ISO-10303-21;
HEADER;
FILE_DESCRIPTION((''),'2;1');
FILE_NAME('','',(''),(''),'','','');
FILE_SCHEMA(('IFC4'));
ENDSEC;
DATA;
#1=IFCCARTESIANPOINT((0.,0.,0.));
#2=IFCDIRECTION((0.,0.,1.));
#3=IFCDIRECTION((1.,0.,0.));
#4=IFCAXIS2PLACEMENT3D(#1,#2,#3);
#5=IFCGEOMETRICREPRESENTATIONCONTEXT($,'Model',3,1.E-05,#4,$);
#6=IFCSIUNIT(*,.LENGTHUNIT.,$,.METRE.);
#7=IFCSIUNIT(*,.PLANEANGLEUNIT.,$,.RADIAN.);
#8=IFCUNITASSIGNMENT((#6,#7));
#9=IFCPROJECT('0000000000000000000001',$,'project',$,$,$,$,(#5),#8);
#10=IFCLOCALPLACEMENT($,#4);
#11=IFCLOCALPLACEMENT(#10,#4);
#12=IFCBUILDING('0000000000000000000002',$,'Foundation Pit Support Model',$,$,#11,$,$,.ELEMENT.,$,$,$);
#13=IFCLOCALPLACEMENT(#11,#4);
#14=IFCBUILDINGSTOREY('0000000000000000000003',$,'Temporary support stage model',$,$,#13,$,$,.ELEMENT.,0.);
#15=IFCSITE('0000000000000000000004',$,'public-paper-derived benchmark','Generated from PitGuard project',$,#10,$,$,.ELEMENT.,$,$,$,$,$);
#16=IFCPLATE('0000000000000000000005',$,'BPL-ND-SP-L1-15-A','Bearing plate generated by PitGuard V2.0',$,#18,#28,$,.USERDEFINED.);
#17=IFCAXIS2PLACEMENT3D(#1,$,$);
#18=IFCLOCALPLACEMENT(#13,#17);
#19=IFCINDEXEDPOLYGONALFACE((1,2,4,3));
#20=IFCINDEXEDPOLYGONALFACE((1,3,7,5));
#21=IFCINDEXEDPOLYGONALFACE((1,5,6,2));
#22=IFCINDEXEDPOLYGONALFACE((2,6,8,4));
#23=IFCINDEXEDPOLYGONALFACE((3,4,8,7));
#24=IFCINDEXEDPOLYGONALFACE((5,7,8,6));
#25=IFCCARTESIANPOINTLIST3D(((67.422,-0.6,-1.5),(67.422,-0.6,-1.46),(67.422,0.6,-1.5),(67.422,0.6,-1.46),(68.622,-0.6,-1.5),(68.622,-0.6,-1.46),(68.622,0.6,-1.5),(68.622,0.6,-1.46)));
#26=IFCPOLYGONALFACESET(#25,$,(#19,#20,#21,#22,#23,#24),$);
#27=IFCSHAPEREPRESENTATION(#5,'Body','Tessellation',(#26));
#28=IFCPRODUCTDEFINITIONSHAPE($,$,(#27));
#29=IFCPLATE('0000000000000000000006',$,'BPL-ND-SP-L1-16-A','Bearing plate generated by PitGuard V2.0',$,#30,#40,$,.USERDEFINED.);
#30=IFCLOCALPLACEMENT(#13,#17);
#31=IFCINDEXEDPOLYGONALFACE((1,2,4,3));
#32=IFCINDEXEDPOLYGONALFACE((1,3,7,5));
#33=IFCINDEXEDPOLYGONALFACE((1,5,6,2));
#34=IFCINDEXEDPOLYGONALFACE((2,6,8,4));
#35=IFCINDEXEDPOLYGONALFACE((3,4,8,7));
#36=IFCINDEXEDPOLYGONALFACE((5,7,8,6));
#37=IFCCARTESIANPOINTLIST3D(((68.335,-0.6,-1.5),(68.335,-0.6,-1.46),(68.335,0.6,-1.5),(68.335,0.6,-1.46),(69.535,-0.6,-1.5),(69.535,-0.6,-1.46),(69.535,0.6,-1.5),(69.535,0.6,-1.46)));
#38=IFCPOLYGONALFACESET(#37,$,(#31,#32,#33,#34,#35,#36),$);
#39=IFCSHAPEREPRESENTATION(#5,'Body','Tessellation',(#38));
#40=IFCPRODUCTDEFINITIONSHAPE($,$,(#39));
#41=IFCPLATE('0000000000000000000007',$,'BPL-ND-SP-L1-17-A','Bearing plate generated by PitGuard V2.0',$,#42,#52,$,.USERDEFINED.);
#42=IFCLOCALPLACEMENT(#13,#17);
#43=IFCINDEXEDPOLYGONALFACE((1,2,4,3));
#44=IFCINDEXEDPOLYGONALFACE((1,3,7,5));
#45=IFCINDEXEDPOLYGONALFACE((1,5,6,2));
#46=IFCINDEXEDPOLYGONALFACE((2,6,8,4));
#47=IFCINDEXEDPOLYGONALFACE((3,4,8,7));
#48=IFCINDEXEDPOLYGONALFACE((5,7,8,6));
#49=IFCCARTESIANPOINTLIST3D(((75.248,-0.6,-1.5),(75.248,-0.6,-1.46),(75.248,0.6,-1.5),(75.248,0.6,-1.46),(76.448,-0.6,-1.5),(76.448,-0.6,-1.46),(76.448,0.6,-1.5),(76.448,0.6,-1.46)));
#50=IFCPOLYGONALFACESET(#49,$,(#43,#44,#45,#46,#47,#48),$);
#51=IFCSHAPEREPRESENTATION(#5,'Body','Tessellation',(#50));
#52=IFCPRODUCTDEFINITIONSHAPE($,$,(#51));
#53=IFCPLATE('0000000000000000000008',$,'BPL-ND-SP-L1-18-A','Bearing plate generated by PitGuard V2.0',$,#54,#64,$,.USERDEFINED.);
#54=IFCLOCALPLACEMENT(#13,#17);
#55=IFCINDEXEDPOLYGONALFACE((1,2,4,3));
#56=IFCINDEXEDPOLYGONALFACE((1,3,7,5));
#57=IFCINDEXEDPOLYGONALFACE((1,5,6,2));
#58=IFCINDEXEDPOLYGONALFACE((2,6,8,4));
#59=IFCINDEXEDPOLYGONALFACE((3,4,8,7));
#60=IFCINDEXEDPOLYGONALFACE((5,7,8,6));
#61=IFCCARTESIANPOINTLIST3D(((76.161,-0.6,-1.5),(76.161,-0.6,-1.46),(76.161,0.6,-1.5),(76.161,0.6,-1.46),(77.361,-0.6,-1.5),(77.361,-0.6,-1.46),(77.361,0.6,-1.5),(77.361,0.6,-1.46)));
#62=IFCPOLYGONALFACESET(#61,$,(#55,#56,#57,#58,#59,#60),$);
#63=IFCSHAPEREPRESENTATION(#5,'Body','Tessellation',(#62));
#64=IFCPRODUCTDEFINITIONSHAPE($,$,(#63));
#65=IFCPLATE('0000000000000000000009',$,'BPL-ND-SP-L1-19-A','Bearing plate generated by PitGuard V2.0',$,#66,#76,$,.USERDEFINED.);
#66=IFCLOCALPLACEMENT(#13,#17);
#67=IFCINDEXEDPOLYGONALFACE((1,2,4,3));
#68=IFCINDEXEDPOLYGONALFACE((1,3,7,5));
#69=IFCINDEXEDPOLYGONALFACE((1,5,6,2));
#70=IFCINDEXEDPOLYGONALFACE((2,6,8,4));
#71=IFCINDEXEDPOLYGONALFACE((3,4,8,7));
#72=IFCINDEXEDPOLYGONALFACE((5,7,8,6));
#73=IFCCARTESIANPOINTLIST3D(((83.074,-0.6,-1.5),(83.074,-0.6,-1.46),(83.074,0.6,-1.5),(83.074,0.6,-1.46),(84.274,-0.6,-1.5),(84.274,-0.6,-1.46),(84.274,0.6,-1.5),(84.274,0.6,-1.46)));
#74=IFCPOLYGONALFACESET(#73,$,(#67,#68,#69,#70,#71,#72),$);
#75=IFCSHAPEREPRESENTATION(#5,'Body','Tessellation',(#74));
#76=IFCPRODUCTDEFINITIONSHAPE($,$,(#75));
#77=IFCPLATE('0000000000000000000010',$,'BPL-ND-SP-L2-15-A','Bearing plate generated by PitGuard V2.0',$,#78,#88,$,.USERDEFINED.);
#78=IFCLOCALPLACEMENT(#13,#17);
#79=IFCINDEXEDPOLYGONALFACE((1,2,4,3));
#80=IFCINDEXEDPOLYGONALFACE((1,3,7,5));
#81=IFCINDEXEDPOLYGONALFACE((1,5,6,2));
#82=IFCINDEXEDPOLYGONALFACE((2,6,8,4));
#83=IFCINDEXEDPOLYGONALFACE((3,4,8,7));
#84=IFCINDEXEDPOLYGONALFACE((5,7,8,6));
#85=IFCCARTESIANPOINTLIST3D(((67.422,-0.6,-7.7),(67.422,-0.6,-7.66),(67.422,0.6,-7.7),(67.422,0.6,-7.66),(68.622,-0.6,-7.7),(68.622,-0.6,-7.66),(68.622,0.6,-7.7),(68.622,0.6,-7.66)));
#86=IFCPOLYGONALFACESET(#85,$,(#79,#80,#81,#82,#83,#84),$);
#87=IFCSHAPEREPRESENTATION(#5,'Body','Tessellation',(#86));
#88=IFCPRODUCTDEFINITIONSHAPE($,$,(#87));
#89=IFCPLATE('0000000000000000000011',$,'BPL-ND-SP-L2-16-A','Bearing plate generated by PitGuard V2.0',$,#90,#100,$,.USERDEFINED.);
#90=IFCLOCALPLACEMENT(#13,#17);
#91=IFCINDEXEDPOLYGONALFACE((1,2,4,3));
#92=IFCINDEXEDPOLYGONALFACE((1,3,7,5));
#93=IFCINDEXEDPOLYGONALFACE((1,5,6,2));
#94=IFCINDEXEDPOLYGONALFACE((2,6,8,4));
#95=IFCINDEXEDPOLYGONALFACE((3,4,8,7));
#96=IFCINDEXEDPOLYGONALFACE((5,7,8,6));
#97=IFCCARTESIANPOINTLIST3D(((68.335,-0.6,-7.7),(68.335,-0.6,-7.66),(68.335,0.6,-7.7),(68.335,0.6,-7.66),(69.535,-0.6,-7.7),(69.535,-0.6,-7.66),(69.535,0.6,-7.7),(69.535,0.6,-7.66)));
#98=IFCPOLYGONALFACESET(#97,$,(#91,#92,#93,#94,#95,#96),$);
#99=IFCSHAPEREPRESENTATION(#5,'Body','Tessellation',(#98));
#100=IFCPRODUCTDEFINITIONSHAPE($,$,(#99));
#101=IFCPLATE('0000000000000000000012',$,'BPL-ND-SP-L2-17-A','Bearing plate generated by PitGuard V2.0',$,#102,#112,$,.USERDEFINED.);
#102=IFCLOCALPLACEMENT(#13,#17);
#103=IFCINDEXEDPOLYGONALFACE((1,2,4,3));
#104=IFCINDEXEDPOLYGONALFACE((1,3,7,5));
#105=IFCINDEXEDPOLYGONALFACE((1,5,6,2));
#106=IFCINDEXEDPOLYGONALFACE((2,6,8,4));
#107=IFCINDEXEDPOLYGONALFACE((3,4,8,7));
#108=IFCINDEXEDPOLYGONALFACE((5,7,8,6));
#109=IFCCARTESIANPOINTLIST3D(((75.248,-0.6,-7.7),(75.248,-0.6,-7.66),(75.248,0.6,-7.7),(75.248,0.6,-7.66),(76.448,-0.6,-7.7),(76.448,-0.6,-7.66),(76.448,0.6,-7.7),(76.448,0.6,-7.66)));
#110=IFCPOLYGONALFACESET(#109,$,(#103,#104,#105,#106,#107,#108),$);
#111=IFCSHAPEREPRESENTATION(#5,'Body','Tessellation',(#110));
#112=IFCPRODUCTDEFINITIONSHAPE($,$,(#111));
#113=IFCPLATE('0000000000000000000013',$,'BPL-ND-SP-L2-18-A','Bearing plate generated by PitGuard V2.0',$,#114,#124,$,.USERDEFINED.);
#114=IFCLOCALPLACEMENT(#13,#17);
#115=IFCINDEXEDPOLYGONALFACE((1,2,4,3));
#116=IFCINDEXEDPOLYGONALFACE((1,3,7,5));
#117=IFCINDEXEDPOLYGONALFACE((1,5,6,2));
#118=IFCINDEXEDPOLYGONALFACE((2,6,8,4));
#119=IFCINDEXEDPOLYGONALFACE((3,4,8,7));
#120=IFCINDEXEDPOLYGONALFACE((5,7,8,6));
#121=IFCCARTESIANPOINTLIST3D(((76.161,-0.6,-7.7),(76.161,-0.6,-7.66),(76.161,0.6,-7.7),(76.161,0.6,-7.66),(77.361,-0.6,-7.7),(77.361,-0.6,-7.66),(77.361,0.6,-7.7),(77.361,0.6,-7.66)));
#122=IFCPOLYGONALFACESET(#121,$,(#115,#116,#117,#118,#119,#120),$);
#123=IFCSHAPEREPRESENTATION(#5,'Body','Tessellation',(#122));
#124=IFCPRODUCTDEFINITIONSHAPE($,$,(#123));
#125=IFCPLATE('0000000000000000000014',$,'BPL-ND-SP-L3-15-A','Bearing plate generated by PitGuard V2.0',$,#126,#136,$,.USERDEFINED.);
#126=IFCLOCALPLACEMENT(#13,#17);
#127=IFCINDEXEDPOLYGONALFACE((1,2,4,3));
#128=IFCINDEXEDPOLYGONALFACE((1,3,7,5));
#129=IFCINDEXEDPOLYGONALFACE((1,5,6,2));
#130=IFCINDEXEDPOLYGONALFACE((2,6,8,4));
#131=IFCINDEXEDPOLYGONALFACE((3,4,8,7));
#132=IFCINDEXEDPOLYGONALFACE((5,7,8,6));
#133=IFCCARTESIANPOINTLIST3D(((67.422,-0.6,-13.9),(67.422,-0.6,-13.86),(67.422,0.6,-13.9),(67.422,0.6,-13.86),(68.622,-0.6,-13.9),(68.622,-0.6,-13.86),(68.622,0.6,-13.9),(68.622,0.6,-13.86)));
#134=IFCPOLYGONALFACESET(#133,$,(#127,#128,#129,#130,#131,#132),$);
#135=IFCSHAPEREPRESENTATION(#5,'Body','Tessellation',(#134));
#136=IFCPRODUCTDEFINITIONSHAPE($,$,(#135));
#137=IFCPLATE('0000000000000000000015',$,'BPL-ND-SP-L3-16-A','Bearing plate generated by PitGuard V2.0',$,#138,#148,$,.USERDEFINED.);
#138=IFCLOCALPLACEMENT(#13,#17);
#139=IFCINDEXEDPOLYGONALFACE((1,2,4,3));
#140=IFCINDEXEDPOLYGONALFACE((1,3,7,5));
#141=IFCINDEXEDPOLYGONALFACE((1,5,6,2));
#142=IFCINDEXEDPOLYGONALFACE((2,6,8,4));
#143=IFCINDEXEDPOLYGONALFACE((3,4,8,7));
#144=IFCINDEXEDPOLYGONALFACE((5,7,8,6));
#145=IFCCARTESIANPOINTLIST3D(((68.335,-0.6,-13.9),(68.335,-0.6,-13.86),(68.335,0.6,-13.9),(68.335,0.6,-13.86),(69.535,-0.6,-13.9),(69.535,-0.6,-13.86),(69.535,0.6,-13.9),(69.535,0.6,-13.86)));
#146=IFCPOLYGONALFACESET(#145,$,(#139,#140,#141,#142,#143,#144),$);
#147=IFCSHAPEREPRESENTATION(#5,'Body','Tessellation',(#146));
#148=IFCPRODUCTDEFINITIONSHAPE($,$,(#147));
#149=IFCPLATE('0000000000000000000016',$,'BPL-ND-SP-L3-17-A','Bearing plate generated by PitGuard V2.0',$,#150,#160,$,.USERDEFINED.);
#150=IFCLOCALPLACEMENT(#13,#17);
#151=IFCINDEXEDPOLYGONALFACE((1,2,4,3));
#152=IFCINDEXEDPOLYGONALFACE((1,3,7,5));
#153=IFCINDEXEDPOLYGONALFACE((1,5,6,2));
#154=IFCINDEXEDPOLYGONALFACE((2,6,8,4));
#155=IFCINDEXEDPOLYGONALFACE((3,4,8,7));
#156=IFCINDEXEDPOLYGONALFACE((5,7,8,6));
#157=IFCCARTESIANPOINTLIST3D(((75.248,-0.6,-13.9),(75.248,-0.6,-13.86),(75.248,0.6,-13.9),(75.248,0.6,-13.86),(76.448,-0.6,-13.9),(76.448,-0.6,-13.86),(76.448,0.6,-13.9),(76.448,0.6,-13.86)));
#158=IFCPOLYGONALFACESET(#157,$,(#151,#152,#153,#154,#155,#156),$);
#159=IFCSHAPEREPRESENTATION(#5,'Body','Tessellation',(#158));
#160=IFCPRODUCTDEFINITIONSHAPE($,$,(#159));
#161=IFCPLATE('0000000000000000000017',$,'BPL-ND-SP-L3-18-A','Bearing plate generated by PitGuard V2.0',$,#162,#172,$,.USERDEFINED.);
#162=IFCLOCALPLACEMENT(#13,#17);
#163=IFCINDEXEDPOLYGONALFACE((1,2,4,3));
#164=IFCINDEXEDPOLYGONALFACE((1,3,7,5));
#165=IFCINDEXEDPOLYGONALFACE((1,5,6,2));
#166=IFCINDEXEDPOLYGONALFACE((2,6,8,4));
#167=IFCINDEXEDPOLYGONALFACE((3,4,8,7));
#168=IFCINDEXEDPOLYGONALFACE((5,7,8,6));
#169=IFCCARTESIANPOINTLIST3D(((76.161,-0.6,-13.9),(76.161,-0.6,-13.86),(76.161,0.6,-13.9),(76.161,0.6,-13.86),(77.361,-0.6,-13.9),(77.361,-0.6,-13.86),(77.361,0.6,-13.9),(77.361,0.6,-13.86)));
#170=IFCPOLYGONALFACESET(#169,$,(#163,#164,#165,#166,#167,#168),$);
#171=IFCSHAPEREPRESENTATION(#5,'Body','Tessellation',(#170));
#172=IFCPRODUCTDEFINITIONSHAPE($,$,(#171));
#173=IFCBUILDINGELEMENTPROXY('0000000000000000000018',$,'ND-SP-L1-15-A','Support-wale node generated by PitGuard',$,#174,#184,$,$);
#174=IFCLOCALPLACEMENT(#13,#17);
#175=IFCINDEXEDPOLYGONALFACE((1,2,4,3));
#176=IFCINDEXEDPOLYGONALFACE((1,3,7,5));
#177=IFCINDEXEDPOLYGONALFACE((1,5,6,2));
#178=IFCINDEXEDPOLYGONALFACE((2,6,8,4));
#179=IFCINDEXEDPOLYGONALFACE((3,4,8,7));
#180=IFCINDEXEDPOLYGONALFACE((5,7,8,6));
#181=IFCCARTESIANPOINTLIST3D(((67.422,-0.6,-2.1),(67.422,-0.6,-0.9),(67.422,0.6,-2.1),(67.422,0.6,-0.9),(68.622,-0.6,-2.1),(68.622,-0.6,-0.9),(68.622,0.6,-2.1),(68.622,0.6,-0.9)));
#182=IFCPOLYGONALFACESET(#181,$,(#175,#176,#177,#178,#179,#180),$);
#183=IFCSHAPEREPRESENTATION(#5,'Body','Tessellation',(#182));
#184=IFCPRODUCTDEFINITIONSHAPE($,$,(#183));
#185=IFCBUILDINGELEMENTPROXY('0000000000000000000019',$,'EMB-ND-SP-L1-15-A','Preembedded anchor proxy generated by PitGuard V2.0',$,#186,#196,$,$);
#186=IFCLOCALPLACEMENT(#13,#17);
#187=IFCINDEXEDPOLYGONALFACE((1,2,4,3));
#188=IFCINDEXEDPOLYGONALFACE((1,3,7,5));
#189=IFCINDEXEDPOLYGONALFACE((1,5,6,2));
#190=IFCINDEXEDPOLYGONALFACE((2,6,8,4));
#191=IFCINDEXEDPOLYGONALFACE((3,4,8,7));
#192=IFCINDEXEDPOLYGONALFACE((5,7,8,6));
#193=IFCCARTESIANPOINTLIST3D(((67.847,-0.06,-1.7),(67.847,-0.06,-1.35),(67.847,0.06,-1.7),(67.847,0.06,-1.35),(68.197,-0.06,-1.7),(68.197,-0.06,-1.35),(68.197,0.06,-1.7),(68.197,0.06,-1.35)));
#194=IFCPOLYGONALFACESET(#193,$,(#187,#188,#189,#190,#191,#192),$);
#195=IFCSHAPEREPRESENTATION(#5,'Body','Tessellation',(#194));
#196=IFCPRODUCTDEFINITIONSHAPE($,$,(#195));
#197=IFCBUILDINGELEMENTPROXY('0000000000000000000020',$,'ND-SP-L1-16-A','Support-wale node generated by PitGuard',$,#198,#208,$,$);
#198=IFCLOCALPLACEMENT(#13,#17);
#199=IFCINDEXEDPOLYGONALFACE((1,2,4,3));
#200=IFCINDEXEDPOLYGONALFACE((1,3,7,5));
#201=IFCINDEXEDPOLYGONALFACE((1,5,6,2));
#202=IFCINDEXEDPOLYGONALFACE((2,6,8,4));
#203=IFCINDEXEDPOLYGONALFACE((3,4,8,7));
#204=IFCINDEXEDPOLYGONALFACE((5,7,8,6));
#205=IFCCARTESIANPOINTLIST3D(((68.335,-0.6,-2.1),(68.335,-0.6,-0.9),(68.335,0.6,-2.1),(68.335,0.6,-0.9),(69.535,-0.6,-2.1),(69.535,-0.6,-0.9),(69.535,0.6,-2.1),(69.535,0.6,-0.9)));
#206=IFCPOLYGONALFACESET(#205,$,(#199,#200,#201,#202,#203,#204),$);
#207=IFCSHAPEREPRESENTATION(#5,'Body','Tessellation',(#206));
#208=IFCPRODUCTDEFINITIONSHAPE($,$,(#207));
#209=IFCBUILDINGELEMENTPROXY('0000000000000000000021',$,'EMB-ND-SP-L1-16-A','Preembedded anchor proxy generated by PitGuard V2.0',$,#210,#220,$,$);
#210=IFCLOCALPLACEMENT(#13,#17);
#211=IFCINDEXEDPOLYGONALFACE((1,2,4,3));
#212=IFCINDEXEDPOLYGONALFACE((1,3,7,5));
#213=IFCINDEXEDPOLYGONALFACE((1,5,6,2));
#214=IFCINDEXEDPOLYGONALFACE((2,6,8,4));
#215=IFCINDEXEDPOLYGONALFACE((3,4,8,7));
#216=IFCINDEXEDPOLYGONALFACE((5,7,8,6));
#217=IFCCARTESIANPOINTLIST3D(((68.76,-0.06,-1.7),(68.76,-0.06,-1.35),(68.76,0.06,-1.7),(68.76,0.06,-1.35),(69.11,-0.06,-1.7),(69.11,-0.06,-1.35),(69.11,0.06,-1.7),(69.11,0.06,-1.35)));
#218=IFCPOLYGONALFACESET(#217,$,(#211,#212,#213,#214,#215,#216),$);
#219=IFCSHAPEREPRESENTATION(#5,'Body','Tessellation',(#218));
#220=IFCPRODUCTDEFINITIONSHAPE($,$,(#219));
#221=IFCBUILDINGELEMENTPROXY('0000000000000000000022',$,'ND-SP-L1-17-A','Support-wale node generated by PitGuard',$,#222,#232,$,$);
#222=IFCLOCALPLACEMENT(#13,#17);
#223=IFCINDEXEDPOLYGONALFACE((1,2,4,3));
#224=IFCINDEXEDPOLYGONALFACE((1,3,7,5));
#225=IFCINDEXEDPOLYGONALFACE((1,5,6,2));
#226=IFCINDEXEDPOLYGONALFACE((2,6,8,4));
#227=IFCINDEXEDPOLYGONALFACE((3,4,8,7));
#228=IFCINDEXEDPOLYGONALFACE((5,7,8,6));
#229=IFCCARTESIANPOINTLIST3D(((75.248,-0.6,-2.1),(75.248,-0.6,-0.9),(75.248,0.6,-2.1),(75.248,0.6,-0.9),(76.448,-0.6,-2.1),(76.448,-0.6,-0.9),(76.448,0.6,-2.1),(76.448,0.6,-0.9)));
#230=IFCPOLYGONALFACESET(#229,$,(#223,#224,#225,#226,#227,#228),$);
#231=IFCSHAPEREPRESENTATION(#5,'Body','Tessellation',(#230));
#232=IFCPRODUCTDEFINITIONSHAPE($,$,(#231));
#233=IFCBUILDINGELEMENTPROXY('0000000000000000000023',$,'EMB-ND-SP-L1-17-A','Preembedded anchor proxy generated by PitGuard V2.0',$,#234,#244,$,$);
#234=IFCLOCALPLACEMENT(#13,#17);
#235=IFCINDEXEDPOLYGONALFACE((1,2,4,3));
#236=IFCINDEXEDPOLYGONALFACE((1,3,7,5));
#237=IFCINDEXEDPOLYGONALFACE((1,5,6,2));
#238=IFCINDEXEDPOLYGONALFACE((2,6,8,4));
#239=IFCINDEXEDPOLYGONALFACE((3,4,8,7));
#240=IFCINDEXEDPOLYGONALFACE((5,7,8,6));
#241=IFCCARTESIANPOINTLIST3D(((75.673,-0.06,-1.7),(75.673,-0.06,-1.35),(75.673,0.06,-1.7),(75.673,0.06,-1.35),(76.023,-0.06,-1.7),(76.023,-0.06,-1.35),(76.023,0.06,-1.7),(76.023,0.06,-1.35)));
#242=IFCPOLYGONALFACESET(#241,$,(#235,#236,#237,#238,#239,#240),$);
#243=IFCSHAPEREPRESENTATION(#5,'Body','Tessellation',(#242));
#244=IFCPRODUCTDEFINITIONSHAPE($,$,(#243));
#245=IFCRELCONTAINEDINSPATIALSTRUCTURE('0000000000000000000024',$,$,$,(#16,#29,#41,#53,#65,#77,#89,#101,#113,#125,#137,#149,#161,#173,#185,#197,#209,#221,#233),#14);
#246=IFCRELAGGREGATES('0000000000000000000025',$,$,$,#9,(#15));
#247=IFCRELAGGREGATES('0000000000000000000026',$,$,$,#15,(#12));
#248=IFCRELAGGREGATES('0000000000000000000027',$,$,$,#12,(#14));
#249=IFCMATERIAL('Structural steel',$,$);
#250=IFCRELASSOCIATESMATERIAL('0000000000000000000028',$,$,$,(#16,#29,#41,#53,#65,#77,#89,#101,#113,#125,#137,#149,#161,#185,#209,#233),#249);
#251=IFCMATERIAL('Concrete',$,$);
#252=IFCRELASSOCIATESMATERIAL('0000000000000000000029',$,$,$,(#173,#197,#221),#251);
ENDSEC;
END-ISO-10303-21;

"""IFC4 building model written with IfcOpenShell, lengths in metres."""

from ifc_helpers import new_model, si_unit, frame, origin_with_axes, origin_2d, place, context, project, spatial, rectangle, extrude, material, element, save


model = new_model("IFC4")

# Units and contexts
model_context = context("Model", 3, precision=1e-05, world=origin_with_axes())
ifc_project = project(units=[si_unit("LENGTHUNIT", "METRE"), si_unit("PLANEANGLEUNIT", "RADIAN")], contexts=[model_context])

# Site, building, storey
site_placement = place(None, origin_with_axes())
site = spatial("IfcSite", under=ifc_project, at=site_placement, Name="public-paper-derived benchmark", Description="Generated from PitGuard project", CompositionType="ELEMENT")
building_placement = place(site_placement, origin_with_axes())
building = spatial("IfcBuilding", under=site, at=building_placement, Name="Foundation Pit Support Model", CompositionType="ELEMENT")
storey_placement = place(building_placement, origin_with_axes())
storey = spatial("IfcBuildingStorey", under=building, at=storey_placement, Name="Temporary support stage model", CompositionType="ELEMENT", Elevation=0.0)

# Plates
ifc_material_1 = material(Name="Structural steel")
for number, where, z_axis, x_axis, name in (
    (1, (68.022, 0.0, -1.5), (0.0, 0.0, 1.0), (1.0, 0.0, 0.0), "BPL-ND-SP-L1-15-A"),
    (2, (68.935, 0.0, -1.5), (0.0, 0.0, 1.0), (1.0, 0.0, 0.0), "BPL-ND-SP-L1-16-A"),
    (3, (75.848, 0.0, -1.5), (0.0, 0.0, 1.0), (1.0, 0.0, 0.0), "BPL-ND-SP-L1-17-A"),
    (4, (76.761, 0.0, -1.5), (0.0, 0.0, 1.0), (1.0, 0.0, 0.0), "BPL-ND-SP-L1-18-A"),
    (5, (83.674, 0.0, -1.5), (0.0, 0.0, 1.0), (1.0, 0.0, 0.0), "BPL-ND-SP-L1-19-A"),
    (6, (68.022, 0.0, -7.7), (0.0, 0.0, 1.0), (1.0, 0.0, 0.0), "BPL-ND-SP-L2-15-A"),
    (7, (68.935, 0.0, -7.7), (0.0, 0.0, 1.0), (1.0, 0.0, 0.0), "BPL-ND-SP-L2-16-A"),
    (8, (75.848, 0.0, -7.7), (0.0, 0.0, 1.0), (1.0, 0.0, 0.0), "BPL-ND-SP-L2-17-A"),
    (9, (76.761, 0.0, -7.7), (0.0, 0.0, 1.0), (1.0, 0.0, 0.0), "BPL-ND-SP-L2-18-A"),
    (10, (68.022, 0.0, -13.9), (0.0, 0.0, 1.0), (1.0, 0.0, 0.0), "BPL-ND-SP-L3-15-A"),
    (11, (68.935, 0.0, -13.9), (0.0, 0.0, 1.0), (1.0, 0.0, 0.0), "BPL-ND-SP-L3-16-A"),
    (12, (75.848, 0.0, -13.9), (0.0, 0.0, 1.0), (1.0, 0.0, 0.0), "BPL-ND-SP-L3-17-A"),
    (13, (76.761, 0.0, -13.9), (0.0, 0.0, 1.0), (1.0, 0.0, 0.0), "BPL-ND-SP-L3-18-A"),
):
    element("IfcPlate", number, at=place(storey_placement, frame(where, z_axis=z_axis, x_axis=x_axis)), inside=storey, material=ifc_material_1, Name=name, Description="Bearing plate generated by PitGuard V2.0", PredefinedType="USERDEFINED", context=model_context, shape_type="SweptSolid", body=[
        extrude(rectangle(XDim=1.2, YDim=1.2, at=origin_2d()), origin_with_axes(), (0.0, 0.0, 1.0), 0.04),
    ])

# Building element proxies
ifc_material_2 = material(Name="Concrete")
proxy_1_placement = place(storey_placement, frame((68.022, 0.0, -2.1), z_axis=(0.0, 0.0, 1.0), x_axis=(1.0, 0.0, 0.0)))
element("IfcBuildingElementProxy", 14, at=proxy_1_placement, inside=storey, material=ifc_material_2, Name="ND-SP-L1-15-A", Description="Support-wale node generated by PitGuard", context=model_context, shape_type="SweptSolid", body=[
    extrude(rectangle(XDim=1.2, YDim=1.2, at=origin_2d()), origin_with_axes(), (0.0, 0.0, 1.0), 1.2),
])
proxy_2_placement = place(storey_placement, frame((68.022, 0.0, -1.7), z_axis=(0.0, 0.0, 1.0), x_axis=(1.0, 0.0, 0.0)))
element("IfcBuildingElementProxy", 15, at=proxy_2_placement, inside=storey, material=ifc_material_1, Name="EMB-ND-SP-L1-15-A", Description="Preembedded anchor proxy generated by PitGuard V2.0", context=model_context, shape_type="SweptSolid", body=[
    extrude(rectangle(XDim=0.35, YDim=0.12, at=origin_2d()), origin_with_axes(), (0.0, 0.0, 1.0), 0.35),
])
proxy_3_placement = place(storey_placement, frame((68.935, 0.0, -2.1), z_axis=(0.0, 0.0, 1.0), x_axis=(1.0, 0.0, 0.0)))
element("IfcBuildingElementProxy", 16, at=proxy_3_placement, inside=storey, material=ifc_material_2, Name="ND-SP-L1-16-A", Description="Support-wale node generated by PitGuard", context=model_context, shape_type="SweptSolid", body=[
    extrude(rectangle(XDim=1.2, YDim=1.2, at=origin_2d()), origin_with_axes(), (0.0, 0.0, 1.0), 1.2),
])
proxy_4_placement = place(storey_placement, frame((68.935, 0.0, -1.7), z_axis=(0.0, 0.0, 1.0), x_axis=(1.0, 0.0, 0.0)))
element("IfcBuildingElementProxy", 17, at=proxy_4_placement, inside=storey, material=ifc_material_1, Name="EMB-ND-SP-L1-16-A", Description="Preembedded anchor proxy generated by PitGuard V2.0", context=model_context, shape_type="SweptSolid", body=[
    extrude(rectangle(XDim=0.35, YDim=0.12, at=origin_2d()), origin_with_axes(), (0.0, 0.0, 1.0), 0.35),
])
proxy_5_placement = place(storey_placement, frame((75.848, 0.0, -2.1), z_axis=(0.0, 0.0, 1.0), x_axis=(1.0, 0.0, 0.0)))
element("IfcBuildingElementProxy", 18, at=proxy_5_placement, inside=storey, material=ifc_material_2, Name="ND-SP-L1-17-A", Description="Support-wale node generated by PitGuard", context=model_context, shape_type="SweptSolid", body=[
    extrude(rectangle(XDim=1.2, YDim=1.2, at=origin_2d()), origin_with_axes(), (0.0, 0.0, 1.0), 1.2),
])
proxy_6_placement = place(storey_placement, frame((75.848, 0.0, -1.7), z_axis=(0.0, 0.0, 1.0), x_axis=(1.0, 0.0, 0.0)))
element("IfcBuildingElementProxy", 19, at=proxy_6_placement, inside=storey, material=ifc_material_1, Name="EMB-ND-SP-L1-17-A", Description="Preembedded anchor proxy generated by PitGuard V2.0", context=model_context, shape_type="SweptSolid", body=[
    extrude(rectangle(XDim=0.35, YDim=0.12, at=origin_2d()), origin_with_axes(), (0.0, 0.0, 1.0), 0.35),
])

save(model, "model.ifc")
